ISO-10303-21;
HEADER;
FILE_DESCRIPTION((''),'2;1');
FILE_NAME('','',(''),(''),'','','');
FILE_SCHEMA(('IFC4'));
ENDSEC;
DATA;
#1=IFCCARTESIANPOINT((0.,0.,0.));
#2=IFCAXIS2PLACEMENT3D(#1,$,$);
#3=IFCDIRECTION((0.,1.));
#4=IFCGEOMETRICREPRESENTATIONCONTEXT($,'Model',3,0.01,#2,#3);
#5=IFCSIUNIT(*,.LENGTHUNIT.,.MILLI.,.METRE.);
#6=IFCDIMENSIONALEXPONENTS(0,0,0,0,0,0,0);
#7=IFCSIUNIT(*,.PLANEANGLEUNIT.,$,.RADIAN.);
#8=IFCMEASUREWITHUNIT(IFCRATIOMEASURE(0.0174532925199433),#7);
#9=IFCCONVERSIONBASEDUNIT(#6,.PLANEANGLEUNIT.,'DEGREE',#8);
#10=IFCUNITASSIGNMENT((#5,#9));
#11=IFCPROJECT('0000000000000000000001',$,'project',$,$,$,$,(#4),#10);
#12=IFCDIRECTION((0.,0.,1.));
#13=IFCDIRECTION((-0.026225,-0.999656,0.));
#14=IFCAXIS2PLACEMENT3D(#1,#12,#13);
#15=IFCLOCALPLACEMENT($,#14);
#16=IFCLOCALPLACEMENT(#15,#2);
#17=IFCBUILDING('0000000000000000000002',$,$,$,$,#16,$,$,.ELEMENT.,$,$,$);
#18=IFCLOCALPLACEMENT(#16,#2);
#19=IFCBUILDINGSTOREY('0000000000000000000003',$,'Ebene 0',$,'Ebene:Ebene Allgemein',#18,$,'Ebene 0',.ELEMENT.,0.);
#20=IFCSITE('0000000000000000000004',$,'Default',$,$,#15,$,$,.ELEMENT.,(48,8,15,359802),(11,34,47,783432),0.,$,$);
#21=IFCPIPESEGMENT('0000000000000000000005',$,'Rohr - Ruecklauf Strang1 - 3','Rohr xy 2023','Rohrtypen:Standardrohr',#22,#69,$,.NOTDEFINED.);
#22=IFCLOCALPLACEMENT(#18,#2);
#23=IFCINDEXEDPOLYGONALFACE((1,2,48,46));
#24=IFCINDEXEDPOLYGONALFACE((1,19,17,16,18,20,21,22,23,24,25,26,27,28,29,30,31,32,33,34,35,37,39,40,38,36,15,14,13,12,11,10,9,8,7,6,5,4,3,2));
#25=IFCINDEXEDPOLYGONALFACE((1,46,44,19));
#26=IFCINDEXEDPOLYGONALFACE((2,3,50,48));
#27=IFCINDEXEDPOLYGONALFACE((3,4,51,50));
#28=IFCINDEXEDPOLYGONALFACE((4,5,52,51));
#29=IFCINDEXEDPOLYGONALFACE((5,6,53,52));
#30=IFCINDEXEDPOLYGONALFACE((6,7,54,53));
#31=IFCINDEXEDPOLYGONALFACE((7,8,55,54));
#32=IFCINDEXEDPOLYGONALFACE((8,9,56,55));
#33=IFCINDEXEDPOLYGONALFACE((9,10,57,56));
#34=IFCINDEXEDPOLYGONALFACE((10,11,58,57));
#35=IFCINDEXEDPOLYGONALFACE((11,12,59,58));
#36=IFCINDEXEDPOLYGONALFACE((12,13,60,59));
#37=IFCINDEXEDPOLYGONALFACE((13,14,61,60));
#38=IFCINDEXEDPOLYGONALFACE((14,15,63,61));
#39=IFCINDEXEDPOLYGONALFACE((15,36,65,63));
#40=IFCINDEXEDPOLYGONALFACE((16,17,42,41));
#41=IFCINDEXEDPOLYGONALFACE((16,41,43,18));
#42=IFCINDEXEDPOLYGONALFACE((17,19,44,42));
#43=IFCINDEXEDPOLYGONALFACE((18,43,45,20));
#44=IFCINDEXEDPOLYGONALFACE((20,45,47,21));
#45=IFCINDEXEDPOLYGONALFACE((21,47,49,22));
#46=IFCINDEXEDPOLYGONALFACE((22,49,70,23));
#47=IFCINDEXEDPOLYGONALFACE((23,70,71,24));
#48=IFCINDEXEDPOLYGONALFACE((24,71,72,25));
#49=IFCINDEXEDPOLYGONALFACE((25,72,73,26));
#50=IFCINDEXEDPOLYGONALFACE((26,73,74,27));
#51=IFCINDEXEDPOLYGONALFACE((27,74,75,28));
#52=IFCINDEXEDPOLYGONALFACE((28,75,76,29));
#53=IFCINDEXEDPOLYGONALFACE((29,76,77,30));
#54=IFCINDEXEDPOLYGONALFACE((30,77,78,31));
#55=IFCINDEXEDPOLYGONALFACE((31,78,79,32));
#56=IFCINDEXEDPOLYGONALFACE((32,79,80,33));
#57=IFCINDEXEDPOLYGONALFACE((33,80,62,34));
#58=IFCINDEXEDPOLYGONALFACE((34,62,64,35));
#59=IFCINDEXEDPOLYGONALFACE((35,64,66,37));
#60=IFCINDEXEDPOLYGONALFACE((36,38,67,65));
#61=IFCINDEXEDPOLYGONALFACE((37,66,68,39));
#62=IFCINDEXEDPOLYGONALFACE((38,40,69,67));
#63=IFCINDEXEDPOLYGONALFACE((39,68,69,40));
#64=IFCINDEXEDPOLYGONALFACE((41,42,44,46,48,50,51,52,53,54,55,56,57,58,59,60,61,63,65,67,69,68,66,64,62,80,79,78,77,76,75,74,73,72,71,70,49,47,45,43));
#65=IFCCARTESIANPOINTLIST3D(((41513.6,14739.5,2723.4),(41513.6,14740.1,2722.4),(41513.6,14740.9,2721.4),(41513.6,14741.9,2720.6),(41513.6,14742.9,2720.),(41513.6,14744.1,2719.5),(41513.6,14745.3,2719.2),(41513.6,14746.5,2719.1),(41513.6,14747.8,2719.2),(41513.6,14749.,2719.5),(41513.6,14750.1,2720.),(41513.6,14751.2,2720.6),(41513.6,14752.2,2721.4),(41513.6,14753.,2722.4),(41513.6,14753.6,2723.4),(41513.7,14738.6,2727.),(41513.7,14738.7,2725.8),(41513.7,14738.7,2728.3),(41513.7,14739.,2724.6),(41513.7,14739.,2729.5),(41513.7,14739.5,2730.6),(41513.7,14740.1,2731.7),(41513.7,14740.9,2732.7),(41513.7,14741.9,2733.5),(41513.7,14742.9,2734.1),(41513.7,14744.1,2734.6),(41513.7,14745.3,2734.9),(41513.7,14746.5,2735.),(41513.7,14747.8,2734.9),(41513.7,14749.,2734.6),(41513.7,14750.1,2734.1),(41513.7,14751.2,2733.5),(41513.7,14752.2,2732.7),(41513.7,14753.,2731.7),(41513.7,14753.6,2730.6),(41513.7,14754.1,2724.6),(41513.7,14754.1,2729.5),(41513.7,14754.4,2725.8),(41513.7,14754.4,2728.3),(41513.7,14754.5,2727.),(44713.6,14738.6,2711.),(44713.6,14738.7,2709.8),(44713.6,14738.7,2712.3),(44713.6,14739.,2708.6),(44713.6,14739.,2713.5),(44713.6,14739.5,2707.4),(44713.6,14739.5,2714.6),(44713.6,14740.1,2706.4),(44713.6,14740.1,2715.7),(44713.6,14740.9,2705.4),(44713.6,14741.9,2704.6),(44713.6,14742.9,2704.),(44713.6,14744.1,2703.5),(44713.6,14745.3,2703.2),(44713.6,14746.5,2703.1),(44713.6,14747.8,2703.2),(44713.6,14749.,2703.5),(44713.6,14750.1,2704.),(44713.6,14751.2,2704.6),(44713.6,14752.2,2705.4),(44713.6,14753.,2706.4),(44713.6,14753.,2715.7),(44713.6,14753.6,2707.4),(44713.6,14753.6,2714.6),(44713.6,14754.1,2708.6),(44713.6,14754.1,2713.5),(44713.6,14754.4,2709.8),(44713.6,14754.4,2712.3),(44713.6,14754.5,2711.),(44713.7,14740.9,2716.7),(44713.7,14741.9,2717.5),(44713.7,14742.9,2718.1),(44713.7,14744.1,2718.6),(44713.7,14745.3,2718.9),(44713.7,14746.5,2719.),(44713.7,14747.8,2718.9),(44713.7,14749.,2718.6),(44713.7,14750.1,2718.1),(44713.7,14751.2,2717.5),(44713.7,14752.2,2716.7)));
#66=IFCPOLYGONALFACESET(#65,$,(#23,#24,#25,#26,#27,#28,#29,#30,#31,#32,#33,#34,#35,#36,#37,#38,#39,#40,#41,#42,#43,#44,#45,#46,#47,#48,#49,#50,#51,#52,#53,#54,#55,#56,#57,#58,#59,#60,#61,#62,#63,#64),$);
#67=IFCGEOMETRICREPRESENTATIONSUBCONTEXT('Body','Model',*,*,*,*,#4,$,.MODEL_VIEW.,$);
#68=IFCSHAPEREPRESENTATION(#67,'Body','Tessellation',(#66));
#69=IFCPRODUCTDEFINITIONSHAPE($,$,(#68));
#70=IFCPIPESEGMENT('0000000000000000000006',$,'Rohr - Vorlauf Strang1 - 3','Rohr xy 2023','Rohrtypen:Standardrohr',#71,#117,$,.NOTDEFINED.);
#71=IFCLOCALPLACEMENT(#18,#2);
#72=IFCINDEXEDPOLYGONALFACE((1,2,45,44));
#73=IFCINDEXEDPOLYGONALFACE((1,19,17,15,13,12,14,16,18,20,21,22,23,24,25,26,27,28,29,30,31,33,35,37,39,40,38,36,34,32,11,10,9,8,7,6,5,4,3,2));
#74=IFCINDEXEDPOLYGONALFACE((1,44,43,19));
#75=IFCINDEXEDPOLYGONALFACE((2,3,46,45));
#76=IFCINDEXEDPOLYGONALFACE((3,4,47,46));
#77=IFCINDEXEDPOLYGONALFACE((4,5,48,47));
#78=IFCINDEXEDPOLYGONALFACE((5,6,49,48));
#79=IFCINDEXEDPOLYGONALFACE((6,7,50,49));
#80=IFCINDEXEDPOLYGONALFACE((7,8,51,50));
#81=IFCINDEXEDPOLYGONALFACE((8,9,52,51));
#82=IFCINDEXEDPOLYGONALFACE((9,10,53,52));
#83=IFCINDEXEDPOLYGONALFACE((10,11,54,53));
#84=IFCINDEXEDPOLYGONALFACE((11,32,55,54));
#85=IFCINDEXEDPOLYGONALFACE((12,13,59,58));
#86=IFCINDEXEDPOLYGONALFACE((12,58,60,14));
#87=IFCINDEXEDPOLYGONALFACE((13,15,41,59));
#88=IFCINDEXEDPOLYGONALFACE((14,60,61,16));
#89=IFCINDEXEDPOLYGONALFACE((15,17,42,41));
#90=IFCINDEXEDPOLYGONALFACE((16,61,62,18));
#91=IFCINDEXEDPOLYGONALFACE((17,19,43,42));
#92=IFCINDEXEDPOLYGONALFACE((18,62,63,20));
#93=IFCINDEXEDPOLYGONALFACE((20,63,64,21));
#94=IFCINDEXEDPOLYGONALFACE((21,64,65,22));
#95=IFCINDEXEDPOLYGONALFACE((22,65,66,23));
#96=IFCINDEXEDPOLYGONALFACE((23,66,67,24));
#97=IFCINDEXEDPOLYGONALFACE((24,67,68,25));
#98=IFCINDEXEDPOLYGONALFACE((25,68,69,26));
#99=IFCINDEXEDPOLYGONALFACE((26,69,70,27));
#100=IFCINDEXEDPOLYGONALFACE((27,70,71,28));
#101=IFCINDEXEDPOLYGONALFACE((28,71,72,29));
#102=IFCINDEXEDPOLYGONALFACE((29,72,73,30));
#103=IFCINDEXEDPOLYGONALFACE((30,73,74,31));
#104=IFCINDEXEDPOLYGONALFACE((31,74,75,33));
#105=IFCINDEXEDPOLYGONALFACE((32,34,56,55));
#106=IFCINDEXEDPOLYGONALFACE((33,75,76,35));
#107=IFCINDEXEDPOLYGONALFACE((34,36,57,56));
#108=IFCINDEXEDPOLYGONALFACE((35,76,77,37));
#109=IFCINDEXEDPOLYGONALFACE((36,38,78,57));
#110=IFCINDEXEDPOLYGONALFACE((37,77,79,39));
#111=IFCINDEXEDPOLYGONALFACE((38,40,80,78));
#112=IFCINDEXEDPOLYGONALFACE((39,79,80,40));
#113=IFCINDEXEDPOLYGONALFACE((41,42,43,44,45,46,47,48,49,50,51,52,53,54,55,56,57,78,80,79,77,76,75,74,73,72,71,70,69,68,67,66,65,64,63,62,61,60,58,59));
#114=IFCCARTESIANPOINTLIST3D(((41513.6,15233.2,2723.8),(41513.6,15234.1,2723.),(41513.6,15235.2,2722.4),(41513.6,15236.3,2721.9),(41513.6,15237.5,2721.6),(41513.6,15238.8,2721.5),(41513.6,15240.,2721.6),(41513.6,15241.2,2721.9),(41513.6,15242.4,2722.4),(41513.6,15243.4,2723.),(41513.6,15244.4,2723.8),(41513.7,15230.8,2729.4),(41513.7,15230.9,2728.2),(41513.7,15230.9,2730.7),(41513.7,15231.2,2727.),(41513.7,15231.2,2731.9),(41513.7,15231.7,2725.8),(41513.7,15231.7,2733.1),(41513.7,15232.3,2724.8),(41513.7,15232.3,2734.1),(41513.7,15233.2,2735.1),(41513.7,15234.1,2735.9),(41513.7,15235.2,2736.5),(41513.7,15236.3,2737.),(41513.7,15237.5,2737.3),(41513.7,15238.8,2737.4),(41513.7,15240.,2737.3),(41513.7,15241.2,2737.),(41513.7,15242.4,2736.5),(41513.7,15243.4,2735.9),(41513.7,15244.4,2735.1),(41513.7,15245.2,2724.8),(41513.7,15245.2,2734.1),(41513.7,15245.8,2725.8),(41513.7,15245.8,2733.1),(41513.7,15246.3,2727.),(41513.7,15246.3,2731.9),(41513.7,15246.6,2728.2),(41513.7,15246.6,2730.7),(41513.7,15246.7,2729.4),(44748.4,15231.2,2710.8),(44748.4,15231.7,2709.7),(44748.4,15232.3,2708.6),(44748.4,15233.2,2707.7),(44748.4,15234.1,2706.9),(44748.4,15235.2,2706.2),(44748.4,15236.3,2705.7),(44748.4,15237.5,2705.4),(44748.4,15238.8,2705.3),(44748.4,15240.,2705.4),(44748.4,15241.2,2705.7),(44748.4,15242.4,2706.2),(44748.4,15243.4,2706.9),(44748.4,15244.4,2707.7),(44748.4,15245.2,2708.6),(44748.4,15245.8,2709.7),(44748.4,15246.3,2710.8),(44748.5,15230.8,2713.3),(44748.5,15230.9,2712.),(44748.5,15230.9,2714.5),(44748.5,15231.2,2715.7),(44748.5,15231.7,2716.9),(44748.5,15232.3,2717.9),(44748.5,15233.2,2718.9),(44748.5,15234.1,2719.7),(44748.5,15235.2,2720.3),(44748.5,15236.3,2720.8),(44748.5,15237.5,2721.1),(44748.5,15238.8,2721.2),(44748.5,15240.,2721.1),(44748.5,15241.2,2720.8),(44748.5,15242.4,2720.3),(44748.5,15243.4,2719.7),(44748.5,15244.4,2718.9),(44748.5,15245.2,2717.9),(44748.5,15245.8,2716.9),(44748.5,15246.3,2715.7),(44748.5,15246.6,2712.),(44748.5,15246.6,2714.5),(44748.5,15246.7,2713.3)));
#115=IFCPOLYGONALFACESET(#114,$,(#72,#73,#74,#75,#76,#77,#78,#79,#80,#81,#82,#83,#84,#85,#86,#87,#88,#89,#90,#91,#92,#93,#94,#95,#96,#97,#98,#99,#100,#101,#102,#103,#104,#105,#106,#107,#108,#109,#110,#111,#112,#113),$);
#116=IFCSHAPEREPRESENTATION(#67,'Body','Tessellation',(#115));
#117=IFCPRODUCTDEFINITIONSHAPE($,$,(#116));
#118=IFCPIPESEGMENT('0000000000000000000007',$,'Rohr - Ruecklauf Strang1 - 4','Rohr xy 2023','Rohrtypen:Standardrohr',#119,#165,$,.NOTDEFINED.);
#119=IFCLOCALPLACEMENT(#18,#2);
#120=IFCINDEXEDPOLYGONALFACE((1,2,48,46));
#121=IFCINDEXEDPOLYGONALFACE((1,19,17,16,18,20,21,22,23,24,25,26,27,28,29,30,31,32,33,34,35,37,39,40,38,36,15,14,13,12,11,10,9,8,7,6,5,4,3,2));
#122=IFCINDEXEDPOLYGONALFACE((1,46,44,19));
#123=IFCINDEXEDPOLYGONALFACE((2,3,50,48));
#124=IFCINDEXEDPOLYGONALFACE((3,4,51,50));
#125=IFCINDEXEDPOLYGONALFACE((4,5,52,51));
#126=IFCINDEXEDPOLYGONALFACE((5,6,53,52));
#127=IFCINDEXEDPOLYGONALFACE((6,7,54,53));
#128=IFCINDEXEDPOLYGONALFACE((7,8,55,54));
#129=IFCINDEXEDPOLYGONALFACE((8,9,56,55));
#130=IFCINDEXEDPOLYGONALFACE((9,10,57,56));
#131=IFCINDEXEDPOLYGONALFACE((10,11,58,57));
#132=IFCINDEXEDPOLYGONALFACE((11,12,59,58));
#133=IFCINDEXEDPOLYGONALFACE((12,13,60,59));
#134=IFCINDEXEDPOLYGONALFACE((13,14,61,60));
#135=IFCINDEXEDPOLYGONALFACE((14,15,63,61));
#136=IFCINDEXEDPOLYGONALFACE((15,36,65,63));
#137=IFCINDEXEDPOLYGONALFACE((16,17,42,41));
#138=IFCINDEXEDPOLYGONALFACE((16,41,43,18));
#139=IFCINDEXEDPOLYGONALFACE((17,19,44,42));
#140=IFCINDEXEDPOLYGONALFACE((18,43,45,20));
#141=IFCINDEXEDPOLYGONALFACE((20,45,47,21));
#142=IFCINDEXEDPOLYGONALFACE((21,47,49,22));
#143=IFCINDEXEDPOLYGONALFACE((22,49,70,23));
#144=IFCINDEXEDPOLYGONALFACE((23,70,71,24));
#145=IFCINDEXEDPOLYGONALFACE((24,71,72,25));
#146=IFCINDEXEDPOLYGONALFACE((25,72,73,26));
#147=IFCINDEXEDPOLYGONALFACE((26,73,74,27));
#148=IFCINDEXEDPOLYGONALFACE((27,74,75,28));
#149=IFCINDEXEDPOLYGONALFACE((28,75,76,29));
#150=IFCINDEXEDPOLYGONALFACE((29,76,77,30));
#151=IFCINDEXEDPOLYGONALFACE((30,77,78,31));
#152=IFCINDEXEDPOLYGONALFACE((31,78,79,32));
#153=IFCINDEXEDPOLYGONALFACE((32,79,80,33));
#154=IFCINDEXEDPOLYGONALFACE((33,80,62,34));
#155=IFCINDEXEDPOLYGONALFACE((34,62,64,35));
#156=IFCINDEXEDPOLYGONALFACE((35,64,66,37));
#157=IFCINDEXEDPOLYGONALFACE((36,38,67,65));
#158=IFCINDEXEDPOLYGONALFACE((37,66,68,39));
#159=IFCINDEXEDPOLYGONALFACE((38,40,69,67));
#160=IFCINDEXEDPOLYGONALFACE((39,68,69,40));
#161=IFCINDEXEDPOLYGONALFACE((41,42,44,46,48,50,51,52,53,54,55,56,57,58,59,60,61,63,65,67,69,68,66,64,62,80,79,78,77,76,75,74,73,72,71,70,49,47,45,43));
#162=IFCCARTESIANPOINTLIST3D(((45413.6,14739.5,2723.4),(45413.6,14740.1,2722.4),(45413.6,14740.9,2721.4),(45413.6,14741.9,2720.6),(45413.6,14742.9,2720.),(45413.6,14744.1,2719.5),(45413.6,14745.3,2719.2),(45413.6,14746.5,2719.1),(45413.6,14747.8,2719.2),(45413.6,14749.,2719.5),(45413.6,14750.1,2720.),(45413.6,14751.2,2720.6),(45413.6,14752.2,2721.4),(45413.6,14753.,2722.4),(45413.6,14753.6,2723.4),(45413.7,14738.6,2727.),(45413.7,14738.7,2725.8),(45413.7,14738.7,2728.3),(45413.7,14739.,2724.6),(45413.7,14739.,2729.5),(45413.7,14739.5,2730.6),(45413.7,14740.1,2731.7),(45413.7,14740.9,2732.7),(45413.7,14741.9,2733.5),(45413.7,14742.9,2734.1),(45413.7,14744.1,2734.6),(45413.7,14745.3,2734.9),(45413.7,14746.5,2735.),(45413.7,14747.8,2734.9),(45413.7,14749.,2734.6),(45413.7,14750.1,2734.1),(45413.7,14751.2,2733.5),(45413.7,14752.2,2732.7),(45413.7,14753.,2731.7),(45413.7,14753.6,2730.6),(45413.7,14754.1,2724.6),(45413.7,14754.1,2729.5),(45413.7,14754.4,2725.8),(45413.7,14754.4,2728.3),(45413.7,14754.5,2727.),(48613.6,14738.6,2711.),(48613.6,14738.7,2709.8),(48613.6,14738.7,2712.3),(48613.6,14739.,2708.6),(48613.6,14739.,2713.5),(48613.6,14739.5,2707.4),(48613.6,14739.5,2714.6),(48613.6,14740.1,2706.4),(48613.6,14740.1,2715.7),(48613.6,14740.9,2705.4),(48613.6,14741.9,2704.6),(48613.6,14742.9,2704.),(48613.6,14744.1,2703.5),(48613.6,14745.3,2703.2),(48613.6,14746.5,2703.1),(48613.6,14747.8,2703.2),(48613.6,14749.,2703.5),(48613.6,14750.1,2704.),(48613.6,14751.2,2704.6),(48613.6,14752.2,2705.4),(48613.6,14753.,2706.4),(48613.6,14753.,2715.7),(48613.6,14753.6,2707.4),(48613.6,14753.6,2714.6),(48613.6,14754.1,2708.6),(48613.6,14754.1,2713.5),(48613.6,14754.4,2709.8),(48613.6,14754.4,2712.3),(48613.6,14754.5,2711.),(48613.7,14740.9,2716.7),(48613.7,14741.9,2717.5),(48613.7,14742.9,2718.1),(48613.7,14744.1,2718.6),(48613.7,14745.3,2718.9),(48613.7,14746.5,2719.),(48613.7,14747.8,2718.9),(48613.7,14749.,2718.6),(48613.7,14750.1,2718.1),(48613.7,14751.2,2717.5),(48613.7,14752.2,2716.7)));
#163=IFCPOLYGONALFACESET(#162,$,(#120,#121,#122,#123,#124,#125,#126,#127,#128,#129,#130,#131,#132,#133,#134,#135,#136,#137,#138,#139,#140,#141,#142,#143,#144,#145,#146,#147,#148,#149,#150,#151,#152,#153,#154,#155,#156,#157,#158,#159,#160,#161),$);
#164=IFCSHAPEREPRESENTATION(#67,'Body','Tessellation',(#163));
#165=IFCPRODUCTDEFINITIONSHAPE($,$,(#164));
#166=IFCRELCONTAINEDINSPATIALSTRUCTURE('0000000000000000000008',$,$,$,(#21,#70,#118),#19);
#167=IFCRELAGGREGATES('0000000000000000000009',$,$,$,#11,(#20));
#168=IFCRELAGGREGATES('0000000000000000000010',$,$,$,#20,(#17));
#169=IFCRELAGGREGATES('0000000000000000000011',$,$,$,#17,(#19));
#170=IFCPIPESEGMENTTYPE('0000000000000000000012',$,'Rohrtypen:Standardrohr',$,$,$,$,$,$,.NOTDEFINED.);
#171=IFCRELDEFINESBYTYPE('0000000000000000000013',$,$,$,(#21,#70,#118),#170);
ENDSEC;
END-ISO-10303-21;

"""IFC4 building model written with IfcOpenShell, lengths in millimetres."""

from ifc_helpers import new_model, entity, si_unit, converted_unit, direction, frame, origin, place, context, subcontext, project, spatial, indexed_curve, outline, extrude, type_object, element, save


model = new_model("IFC4")

# Units and contexts
model_context = context("Model", 3, precision=0.01, world=origin(), true_north=direction((0.0, 1.0)))
body_context = subcontext(model_context, "Body", "Model", "MODEL_VIEW")
ifc_project = project(units=[si_unit("LENGTHUNIT", "METRE", prefix="MILLI"), converted_unit("PLANEANGLEUNIT", "DEGREE", entity("IfcRatioMeasure", 0.0174532925199433), si_unit("PLANEANGLEUNIT", "RADIAN"), dimensions=[0, 0, 0, 0, 0, 0, 0])], contexts=[model_context])

# Site, building, storey
site_placement = place(None, frame((0.0, 0.0, 0.0), z_axis=(0.0, 0.0, 1.0), x_axis=(-0.026225, -0.999656, 0.0)))
site = spatial("IfcSite", under=ifc_project, at=site_placement, Name="Default", CompositionType="ELEMENT", RefLatitude=(48, 8, 15, 359802), RefLongitude=(11, 34, 47, 783432), RefElevation=0.0)
building_placement = place(site_placement, origin())
building = spatial("IfcBuilding", under=site, at=building_placement, CompositionType="ELEMENT")
storey_placement = place(building_placement, origin())
storey = spatial("IfcBuildingStorey", under=building, at=storey_placement, Name="Ebene 0", ObjectType="Ebene:Ebene Allgemein", LongName="Ebene 0", CompositionType="ELEMENT", Elevation=0.0)

# Pipe segments
pipe_segment_type = type_object("IfcPipeSegmentType", Name="Rohrtypen:Standardrohr", PredefinedType="NOTDEFINED")
pipe_segment_1_placement = place(storey_placement, origin())
element("IfcPipeSegment", 1, at=pipe_segment_1_placement, inside=storey, type_object=pipe_segment_type, Name="Rohr - Ruecklauf Strang1 - 3", Description="Rohr xy 2023", ObjectType="Rohrtypen:Standardrohr", PredefinedType="NOTDEFINED", context=body_context, shape_type="SweptSolid", body=[
    extrude(outline(indexed_curve([(7.9, 0.0), (7.8, 1.2), (7.6, 2.5), (7.1, 3.6), (6.4, 4.7), (5.6, 5.6), (4.7, 6.4), (3.6, 7.1), (2.5, 7.6), (1.2, 7.8), (0.0, 7.9), (-1.2, 7.8), (-2.5, 7.6), (-3.6, 7.1), (-4.7, 6.4), (-5.6, 5.6), (-6.4, 4.7), (-7.1, 3.6), (-7.6, 2.5), (-7.8, 1.2), (-7.9, 0.0), (-7.8, -1.2), (-7.6, -2.5), (-7.1, -3.6), (-6.4, -4.7), (-5.6, -5.6), (-4.7, -6.4), (-3.6, -7.1), (-2.5, -7.6), (-1.2, -7.8), (0.0, -7.9), (1.2, -7.8), (2.5, -7.6), (3.6, -7.1), (4.7, -6.4), (5.6, -5.6), (6.4, -4.7), (7.1, -3.6), (7.6, -2.5), (7.8, -1.2), (7.9, 0.0)], self_intersect=False)), frame((44713.6, 14746.5, 2711.0), z_axis=(-0.999988, 0.0, 0.005), x_axis=(0.0, 1.0, 0.0)), (0.0, 0.0, 1.0), 3200.0),
])
pipe_segment_2_placement = place(storey_placement, origin())
element("IfcPipeSegment", 2, at=pipe_segment_2_placement, inside=storey, type_object=pipe_segment_type, Name="Rohr - Vorlauf Strang1 - 3", Description="Rohr xy 2023", ObjectType="Rohrtypen:Standardrohr", PredefinedType="NOTDEFINED", context=body_context, shape_type="SweptSolid", body=[
    extrude(outline(indexed_curve([(7.9, 0.0), (7.8, 1.2), (7.6, 2.5), (7.1, 3.6), (6.4, 4.7), (5.6, 5.6), (4.7, 6.4), (3.6, 7.1), (2.5, 7.6), (1.2, 7.8), (0.0, 7.9), (-1.2, 7.8), (-2.5, 7.6), (-3.6, 7.1), (-4.7, 6.4), (-5.6, 5.6), (-6.4, 4.7), (-7.1, 3.6), (-7.6, 2.5), (-7.8, 1.2), (-7.9, 0.0), (-7.8, -1.2), (-7.6, -2.5), (-7.1, -3.6), (-6.4, -4.7), (-5.6, -5.6), (-4.7, -6.4), (-3.6, -7.1), (-2.5, -7.6), (-1.2, -7.8), (0.0, -7.9), (1.2, -7.8), (2.5, -7.6), (3.6, -7.1), (4.7, -6.4), (5.6, -5.6), (6.4, -4.7), (7.1, -3.6), (7.6, -2.5), (7.8, -1.2), (7.9, 0.0)], self_intersect=False)), frame((44748.5, 15238.8, 2713.3), z_axis=(-0.999988, 0.0, 0.005), x_axis=(0.0, 1.0, 0.0)), (0.0, 0.0, 1.0), 3234.8),
])
pipe_segment_3_placement = place(storey_placement, origin())
element("IfcPipeSegment", 3, at=pipe_segment_3_placement, inside=storey, type_object=pipe_segment_type, Name="Rohr - Ruecklauf Strang1 - 4", Description="Rohr xy 2023", ObjectType="Rohrtypen:Standardrohr", PredefinedType="NOTDEFINED", context=body_context, shape_type="SweptSolid", body=[
    extrude(outline(indexed_curve([(7.9, 0.0), (7.8, 1.2), (7.6, 2.5), (7.1, 3.6), (6.4, 4.7), (5.6, 5.6), (4.7, 6.4), (3.6, 7.1), (2.5, 7.6), (1.2, 7.8), (0.0, 7.9), (-1.2, 7.8), (-2.5, 7.6), (-3.6, 7.1), (-4.7, 6.4), (-5.6, 5.6), (-6.4, 4.7), (-7.1, 3.6), (-7.6, 2.5), (-7.8, 1.2), (-7.9, 0.0), (-7.8, -1.2), (-7.6, -2.5), (-7.1, -3.6), (-6.4, -4.7), (-5.6, -5.6), (-4.7, -6.4), (-3.6, -7.1), (-2.5, -7.6), (-1.2, -7.8), (0.0, -7.9), (1.2, -7.8), (2.5, -7.6), (3.6, -7.1), (4.7, -6.4), (5.6, -5.6), (6.4, -4.7), (7.1, -3.6), (7.6, -2.5), (7.8, -1.2), (7.9, 0.0)], self_intersect=False)), frame((48613.6, 14746.5, 2711.0), z_axis=(-0.999988, 0.0, 0.005), x_axis=(0.0, 1.0, 0.0)), (0.0, 0.0, 1.0), 3200.0),
])

save(model, "model.ifc")
